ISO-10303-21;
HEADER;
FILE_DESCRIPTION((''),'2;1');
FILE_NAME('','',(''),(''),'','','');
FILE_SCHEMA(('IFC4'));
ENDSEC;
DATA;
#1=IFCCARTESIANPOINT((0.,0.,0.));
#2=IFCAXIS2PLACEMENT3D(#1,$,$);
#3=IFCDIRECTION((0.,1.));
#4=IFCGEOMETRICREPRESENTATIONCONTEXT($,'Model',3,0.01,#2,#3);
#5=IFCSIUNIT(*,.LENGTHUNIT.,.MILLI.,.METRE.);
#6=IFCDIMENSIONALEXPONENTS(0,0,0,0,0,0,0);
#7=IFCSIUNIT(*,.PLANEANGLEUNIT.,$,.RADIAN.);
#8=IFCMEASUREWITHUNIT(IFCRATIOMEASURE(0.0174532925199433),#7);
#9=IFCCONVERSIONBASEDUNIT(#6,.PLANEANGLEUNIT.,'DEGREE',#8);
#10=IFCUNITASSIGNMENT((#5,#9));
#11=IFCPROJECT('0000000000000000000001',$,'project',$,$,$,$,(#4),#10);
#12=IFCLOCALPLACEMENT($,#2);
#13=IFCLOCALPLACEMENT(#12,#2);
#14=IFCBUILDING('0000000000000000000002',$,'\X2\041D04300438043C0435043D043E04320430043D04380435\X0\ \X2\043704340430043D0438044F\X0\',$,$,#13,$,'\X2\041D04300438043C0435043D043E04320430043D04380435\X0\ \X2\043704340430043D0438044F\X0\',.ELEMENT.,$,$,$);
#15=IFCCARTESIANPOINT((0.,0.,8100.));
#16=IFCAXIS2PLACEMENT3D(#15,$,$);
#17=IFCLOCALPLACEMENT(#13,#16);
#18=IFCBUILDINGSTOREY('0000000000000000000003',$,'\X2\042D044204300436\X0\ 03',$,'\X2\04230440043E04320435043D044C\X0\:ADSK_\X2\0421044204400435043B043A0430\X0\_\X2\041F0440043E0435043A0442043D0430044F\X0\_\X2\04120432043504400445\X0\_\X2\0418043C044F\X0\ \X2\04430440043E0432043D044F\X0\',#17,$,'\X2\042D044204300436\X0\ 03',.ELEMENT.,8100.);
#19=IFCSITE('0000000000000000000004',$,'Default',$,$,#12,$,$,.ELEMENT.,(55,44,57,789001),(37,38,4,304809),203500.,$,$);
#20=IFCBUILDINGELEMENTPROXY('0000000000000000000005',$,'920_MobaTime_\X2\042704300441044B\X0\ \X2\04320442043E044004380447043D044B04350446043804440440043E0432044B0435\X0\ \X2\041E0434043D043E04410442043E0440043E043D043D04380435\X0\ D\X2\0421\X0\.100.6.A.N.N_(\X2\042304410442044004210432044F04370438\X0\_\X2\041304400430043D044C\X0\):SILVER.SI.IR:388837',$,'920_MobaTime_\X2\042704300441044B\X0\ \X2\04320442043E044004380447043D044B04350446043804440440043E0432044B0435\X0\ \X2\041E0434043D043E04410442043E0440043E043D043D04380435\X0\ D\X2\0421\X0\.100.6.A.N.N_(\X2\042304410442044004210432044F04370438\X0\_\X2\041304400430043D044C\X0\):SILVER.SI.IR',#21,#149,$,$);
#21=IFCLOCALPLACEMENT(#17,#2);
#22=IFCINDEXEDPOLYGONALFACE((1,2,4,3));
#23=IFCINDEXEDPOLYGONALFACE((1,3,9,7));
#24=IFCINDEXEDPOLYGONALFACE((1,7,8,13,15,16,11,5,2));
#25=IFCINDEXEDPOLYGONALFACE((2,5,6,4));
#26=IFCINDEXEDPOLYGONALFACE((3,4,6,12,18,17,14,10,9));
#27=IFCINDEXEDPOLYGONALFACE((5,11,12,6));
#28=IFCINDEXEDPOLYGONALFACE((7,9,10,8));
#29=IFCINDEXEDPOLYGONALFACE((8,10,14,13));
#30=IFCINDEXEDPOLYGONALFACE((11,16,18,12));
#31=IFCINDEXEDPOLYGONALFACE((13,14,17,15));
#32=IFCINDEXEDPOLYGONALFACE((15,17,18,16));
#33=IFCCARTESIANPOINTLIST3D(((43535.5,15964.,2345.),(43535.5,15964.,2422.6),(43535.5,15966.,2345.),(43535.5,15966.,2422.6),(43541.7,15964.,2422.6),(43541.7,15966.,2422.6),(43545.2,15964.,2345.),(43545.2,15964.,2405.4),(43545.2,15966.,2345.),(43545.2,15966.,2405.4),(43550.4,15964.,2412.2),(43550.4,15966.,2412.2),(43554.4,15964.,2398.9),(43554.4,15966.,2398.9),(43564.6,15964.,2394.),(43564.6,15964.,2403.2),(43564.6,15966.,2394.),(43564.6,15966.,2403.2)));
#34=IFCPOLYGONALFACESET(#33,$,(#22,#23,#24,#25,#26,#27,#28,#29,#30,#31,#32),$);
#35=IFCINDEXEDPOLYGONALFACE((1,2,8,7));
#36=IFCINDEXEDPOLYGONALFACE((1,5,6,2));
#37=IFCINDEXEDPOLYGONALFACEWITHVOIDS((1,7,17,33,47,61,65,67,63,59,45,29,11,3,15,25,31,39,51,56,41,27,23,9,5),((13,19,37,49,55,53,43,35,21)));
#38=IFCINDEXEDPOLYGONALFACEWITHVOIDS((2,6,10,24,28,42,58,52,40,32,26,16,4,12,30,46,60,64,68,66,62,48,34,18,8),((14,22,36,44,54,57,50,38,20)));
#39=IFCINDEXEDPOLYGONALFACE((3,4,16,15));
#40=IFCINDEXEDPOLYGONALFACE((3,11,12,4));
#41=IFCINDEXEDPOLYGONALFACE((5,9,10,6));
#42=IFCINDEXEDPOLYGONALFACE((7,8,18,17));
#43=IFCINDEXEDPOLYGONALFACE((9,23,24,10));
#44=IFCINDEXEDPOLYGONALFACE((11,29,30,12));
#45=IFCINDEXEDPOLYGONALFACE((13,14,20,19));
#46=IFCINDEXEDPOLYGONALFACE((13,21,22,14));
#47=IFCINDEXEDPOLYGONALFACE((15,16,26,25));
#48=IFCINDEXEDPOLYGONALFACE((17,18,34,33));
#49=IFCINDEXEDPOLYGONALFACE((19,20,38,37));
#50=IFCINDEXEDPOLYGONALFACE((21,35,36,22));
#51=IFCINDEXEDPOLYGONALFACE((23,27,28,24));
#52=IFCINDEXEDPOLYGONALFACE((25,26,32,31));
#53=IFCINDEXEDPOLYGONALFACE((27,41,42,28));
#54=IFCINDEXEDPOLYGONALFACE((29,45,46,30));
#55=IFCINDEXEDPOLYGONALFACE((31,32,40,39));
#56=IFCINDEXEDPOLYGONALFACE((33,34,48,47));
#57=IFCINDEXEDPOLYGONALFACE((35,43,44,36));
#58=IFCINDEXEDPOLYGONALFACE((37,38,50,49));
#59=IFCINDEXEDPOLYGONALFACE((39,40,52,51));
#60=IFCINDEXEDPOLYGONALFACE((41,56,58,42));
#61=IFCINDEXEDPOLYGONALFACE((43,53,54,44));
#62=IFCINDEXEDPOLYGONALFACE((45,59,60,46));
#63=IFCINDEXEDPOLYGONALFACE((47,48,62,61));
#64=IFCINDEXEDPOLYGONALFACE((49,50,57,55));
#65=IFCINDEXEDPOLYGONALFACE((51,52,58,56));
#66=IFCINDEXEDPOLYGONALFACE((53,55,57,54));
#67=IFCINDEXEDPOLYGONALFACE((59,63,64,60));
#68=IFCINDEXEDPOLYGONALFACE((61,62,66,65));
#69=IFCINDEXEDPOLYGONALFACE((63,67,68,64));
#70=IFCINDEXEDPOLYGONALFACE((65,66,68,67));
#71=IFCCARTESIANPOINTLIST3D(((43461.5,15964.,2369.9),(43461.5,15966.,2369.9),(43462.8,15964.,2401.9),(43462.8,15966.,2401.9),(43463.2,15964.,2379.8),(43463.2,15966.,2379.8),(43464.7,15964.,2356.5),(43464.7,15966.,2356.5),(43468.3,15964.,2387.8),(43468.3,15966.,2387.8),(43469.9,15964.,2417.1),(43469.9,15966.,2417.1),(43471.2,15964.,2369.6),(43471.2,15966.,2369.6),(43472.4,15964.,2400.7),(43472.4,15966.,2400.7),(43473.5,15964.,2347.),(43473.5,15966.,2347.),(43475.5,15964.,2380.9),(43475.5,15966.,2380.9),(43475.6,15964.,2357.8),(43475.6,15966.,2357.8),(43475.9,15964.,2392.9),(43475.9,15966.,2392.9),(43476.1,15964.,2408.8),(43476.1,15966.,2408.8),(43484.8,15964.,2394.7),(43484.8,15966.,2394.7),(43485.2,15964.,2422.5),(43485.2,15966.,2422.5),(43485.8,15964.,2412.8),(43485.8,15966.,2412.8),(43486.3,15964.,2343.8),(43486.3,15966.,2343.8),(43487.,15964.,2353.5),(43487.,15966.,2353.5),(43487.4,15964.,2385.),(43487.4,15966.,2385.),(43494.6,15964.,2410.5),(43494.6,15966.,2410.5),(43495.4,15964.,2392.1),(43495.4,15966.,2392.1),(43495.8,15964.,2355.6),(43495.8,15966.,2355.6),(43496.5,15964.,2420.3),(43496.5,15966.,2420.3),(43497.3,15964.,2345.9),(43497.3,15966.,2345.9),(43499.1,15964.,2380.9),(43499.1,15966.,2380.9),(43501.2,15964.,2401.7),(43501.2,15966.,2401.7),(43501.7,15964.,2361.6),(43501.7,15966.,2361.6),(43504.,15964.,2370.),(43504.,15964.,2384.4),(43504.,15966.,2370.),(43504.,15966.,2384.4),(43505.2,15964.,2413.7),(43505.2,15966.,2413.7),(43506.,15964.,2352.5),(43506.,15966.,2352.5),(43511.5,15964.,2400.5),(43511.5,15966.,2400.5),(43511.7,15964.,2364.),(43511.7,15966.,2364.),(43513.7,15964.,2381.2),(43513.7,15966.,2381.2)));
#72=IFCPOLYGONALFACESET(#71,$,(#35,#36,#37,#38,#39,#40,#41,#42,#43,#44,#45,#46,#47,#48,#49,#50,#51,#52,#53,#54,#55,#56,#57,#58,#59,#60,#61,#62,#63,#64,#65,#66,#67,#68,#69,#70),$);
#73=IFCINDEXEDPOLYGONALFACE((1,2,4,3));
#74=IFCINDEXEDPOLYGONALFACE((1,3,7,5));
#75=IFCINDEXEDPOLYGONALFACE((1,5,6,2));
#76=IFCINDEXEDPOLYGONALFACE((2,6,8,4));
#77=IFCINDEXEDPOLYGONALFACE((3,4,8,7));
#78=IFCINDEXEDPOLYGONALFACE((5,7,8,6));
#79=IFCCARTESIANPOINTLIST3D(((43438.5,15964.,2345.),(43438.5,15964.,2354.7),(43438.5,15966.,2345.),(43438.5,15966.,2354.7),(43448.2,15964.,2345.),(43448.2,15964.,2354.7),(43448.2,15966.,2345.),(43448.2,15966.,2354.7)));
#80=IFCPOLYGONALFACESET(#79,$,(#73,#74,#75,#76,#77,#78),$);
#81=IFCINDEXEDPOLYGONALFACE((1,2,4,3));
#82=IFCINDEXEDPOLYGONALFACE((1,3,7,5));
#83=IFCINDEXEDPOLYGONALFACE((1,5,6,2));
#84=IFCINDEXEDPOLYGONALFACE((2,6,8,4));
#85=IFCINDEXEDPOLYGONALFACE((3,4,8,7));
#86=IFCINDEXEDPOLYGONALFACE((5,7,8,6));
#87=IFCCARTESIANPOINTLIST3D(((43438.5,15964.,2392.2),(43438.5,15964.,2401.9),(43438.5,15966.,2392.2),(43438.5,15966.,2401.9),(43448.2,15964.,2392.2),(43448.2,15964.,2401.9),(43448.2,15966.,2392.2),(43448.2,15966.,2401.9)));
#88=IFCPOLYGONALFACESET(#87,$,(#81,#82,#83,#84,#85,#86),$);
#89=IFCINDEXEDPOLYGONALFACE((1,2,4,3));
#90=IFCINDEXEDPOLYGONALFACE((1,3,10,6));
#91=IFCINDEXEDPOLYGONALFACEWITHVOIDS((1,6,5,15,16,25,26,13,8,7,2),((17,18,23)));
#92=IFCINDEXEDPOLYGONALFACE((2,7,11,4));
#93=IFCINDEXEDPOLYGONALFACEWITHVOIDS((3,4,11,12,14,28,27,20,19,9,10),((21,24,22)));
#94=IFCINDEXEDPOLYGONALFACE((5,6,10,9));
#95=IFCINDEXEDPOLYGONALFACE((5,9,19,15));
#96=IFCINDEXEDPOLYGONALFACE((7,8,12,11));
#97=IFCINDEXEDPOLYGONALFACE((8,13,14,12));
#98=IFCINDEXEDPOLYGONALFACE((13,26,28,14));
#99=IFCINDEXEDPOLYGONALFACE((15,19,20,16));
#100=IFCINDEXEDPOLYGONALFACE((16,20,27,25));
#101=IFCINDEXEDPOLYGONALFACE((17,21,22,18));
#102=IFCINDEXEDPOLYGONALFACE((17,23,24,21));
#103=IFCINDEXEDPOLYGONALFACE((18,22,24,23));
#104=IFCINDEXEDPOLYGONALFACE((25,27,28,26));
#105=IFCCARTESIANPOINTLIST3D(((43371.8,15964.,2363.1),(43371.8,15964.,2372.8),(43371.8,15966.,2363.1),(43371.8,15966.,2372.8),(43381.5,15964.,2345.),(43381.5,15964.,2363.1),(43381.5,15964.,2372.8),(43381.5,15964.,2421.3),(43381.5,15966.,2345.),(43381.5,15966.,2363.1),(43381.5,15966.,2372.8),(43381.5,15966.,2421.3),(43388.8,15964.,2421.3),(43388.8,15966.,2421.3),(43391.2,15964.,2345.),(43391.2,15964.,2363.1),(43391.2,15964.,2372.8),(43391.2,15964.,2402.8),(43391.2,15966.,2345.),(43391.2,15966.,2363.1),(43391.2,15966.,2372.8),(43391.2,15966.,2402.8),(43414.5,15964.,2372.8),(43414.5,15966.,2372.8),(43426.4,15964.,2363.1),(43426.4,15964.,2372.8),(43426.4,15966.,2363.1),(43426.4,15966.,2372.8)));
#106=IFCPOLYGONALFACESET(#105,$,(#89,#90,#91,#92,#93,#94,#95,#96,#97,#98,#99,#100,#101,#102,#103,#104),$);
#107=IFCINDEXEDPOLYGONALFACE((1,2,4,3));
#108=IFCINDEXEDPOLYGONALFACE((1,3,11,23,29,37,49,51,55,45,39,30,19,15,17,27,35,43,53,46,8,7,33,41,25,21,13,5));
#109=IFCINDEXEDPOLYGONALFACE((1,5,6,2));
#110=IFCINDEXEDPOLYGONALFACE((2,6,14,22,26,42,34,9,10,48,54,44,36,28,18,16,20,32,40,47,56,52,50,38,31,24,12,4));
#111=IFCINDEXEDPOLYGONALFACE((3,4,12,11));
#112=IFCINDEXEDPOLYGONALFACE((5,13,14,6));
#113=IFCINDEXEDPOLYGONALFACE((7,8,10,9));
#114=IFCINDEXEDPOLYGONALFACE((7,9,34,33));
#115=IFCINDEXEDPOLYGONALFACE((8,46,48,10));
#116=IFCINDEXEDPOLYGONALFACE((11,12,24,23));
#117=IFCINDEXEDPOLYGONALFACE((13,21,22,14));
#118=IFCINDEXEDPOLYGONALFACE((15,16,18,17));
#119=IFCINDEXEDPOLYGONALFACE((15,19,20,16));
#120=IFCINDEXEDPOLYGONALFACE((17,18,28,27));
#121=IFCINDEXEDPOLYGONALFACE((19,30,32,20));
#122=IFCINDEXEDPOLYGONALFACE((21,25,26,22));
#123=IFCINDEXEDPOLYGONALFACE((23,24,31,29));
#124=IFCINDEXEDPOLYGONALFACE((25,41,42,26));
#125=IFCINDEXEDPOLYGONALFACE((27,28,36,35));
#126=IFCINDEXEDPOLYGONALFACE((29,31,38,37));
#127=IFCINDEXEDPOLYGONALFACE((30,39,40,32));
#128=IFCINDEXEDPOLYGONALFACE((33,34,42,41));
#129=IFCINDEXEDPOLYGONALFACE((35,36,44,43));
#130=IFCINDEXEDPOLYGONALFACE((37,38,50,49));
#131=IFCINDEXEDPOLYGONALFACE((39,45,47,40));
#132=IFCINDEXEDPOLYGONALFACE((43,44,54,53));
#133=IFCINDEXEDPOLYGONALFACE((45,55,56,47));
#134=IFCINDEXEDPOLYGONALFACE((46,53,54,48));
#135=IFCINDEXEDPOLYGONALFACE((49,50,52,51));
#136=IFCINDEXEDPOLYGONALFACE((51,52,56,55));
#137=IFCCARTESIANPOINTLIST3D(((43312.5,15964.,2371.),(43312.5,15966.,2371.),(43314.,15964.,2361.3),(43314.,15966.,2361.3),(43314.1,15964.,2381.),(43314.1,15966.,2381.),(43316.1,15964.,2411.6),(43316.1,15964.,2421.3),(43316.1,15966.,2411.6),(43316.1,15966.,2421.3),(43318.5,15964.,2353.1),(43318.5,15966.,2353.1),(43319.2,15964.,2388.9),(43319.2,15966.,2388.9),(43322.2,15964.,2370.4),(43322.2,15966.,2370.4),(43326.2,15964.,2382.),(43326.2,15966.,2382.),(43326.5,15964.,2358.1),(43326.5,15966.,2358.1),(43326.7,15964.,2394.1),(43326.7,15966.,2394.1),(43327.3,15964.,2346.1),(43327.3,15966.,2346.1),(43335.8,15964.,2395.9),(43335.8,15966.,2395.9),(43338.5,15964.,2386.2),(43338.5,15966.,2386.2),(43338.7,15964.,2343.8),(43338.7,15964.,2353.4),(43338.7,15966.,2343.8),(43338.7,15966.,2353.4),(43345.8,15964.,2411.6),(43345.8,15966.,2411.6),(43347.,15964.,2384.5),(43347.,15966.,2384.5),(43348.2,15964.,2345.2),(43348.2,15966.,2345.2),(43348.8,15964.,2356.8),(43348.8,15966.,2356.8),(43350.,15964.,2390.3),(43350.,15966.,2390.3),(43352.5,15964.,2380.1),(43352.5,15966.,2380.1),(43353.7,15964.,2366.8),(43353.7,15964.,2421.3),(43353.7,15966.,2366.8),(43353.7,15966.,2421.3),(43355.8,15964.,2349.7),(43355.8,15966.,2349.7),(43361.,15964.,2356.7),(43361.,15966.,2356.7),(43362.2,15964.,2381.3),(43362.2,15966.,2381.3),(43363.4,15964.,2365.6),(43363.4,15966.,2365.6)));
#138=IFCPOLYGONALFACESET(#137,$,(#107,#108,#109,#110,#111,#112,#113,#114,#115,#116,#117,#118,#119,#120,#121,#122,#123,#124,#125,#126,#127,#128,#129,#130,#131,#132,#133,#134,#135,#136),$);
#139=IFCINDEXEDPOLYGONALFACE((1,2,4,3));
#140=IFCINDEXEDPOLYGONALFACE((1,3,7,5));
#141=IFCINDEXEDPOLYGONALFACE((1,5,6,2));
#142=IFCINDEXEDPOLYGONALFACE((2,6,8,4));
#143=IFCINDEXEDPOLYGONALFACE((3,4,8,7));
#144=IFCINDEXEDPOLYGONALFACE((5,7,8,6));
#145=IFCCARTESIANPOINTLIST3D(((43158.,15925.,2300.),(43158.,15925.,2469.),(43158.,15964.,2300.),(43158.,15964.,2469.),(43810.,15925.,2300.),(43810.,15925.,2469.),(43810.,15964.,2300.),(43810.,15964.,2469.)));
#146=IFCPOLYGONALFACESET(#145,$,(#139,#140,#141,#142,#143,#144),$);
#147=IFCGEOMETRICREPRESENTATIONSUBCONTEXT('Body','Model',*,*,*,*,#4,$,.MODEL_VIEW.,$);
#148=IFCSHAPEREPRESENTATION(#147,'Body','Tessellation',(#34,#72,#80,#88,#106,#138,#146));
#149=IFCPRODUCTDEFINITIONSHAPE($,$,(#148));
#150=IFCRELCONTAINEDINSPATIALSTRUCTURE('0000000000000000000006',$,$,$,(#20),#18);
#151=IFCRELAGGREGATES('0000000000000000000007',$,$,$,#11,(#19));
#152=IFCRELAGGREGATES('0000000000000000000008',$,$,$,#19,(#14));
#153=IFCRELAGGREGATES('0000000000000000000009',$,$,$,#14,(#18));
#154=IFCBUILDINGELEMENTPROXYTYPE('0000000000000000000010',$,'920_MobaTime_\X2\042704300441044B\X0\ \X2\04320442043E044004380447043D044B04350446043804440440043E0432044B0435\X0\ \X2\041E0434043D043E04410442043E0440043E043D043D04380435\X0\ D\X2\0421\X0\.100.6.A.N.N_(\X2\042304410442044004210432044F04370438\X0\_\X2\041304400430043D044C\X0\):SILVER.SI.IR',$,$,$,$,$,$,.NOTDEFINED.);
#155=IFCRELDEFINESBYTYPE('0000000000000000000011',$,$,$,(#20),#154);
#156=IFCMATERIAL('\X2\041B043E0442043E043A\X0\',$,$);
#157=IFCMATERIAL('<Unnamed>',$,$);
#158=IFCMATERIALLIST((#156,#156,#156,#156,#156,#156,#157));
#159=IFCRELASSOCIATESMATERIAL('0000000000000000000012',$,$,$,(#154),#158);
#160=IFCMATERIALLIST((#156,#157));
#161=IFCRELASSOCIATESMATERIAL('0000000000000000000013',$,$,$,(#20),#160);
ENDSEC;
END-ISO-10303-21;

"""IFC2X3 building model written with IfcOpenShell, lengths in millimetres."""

from ifc_helpers import new_model, entity, si_unit, converted_unit, direction, frame, origin, origin_2d_with_axis, place, context, subcontext, project, spatial, polyline, rectangle, outline, extrude, source, transform, mapped, material, material_list, type_object, type_shapes, element, save


model = new_model("IFC2X3")

# Units and contexts
model_context = context("Model", 3, precision=0.01, world=origin(), true_north=direction((0.0, 1.0)))
body_context = subcontext(model_context, "Body", "Model", "MODEL_VIEW")
ifc_project = project(units=[si_unit("LENGTHUNIT", "METRE", prefix="MILLI"), converted_unit("PLANEANGLEUNIT", "DEGREE", entity("IfcRatioMeasure", 0.0174532925199433), si_unit("PLANEANGLEUNIT", "RADIAN"), dimensions=[0, 0, 0, 0, 0, 0, 0])], contexts=[model_context])

# Site, building, storey
site_placement = place(None, origin())
site = spatial("IfcSite", under=ifc_project, at=site_placement, Name="Default", CompositionType="ELEMENT", RefLatitude=(55, 44, 57, 789001), RefLongitude=(37, 38, 4, 304809), RefElevation=203500.0)
building_placement = place(site_placement, origin())
building = spatial("IfcBuilding", under=site, at=building_placement, Name="Наименование здания", LongName="Наименование здания", CompositionType="ELEMENT")
storey_placement = place(building_placement, frame((0.0, 0.0, 8100.0)))
storey = spatial("IfcBuildingStorey", under=building, at=storey_placement, Name="Этаж 03", ObjectType="Уровень:ADSK_Стрелка_Проектная_Вверх_Имя уровня", LongName="Этаж 03", CompositionType="ELEMENT", Elevation=8100.0)

# Building element proxy
ifc_material_1 = material(Name="Лоток")
ifc_material_2 = material(Name="<Unnamed>")
ifc_material_list_1 = material_list([ifc_material_1, ifc_material_1, ifc_material_1, ifc_material_1, ifc_material_1, ifc_material_1, ifc_material_2])
building_element_proxy_type = type_object("IfcBuildingElementProxyType", Name="920_MobaTime_Часы вторичныецифровые Односторонние DС.100.6.A.N.N_(УстрСвязи_Грань):SILVER.SI.IR", PredefinedType="NOTDEFINED", material=ifc_material_list_1)
shared_shape = source(origin(), body_context, "Body", "SweptSolid", [
    extrude(outline(polyline([(-49.3, -13.1), (28.2, -13.1), (28.2, -6.8), (17.9, 1.8), (8.8, 16.0), (-0.3, 16.0), (4.6, 5.8), (11.1, -3.4), (-49.3, -3.4), (-49.3, -13.1)])), frame((-64.6, 9.8, 39.0), z_axis=(0.0, 0.0, 1.0), x_axis=(0.0, 1.0, 0.0)), (0.0, 0.0, 1.0), 2.0),
    extrude(outline(polyline([(2.2, -27.6), (19.0, -27.6), (30.5, -16.1), (33.3, -4.9), (31.0, 5.8), (21.8, 17.2), (5.2, 27.3), (-11.1, 33.0), (-24.0, 32.7), (-33.6, 27.6), (-40.3, 18.6), (-42.8, 5.7), (-38.0, -6.3), (-27.2, -14.9), (-17.5, -17.7), (-8.2, -16.4), (-0.3, -11.9), (5.1, -4.5), (7.3, 6.2), (4.0, 17.2), (18.4, 7.3), (23.6, -2.4), (22.0, -11.4), (14.2, -18.4), (5.3, -18.3), (2.2, -27.6)]), holes=[polyline([(-9.0, 23.3), (-1.3, 14.3), (-2.5, 2.0), (-11.4, -7.0), (-23.4, -6.0), (-32.2, 2.9), (-31.2, 15.1), (-25.6, 22.1), (-17.5, 24.9), (-9.0, 23.3)])]), frame((-2.7, 3.6, 39.0), z_axis=(0.0, 0.0, 1.0), x_axis=(-0.427649, 0.903945, 0.0)), (0.0, 0.0, 1.0), 2.0),
    extrude(rectangle(XDim=9.7, YDim=9.7, at=origin_2d_with_axis()), frame((40.6, -34.7, 39.0)), (0.0, 0.0, 1.0), 2.0),
    extrude(rectangle(XDim=9.7, YDim=9.7, at=origin_2d_with_axis()), frame((40.6, 12.6, 39.0)), (0.0, 0.0, 1.0), 2.0),
    extrude(outline(polyline([(-0.9, -28.1), (8.8, -28.1), (8.8, -9.9), (18.5, -9.9), (18.5, -0.2), (8.8, -0.2), (8.8, 48.3), (1.5, 48.3), (-36.0, -0.2), (-36.0, -9.9), (-0.9, -9.9), (-0.9, -28.1)]), holes=[polyline([(-0.9, -0.2), (-24.1, -0.2), (-0.9, 29.7), (-0.9, -0.2)])]), frame((93.6, -11.4, 39.0)), (0.0, 0.0, 1.0), 2.0),
    extrude(outline(polyline([(3.3, -28.3), (12.5, -28.3), (20.5, -25.0), (26.8, -18.9), (30.7, -10.0), (31.4, 1.6), (26.9, 11.8), (20.1, 18.4), (11.1, 22.3), (1.0, 23.3), (-7.9, 20.4), (-14.9, 14.5), (-18.9, 6.2), (-17.1, -9.0), (-36.7, 0.5), (-29.1, 29.2), (-38.5, 31.7), (-48.1, -4.6), (-11.6, -23.1), (-8.0, -14.0), (-10.8, -7.6), (-10.2, 1.1), (-3.0, 11.8), (9.2, 12.8), (20.0, 5.5), (21.4, -7.5), (15.5, -16.4), (4.6, -18.6), (3.3, -28.3)])), frame((147.1, -8.5, 39.0), z_axis=(0.0, 0.0, 1.0), x_axis=(0.256974, -0.966418, 0.0)), (0.0, 0.0, 1.0), 2.0),
    extrude(rectangle(XDim=652.0, YDim=169.0, at=origin_2d_with_axis()), frame((0.0, 0.0, 0.0), z_axis=(0.0, 0.0, 1.0), x_axis=(-1.0, 0.0, 0.0)), (0.0, 0.0, 1.0), 39.0),
])
type_shapes(building_element_proxy_type, [shared_shape])
ifc_material_list_2 = material_list([ifc_material_1, ifc_material_2])
for number, where, z_axis, x_axis, name in (
    (1, (43484.0, 15925.0, 2384.5), (0.0, 1.0, 0.0), (-1.0, 0.0, 0.0), "920_MobaTime_Часы вторичныецифровые Односторонние DС.100.6.A.N.N_(УстрСвязи_Грань):SILVER.SI.IR:388837"),
):
    element("IfcBuildingElementProxy", number, at=place(storey_placement, frame(where, z_axis=z_axis, x_axis=x_axis)), inside=storey, type_object=building_element_proxy_type, material=ifc_material_list_2, Name=name, ObjectType="920_MobaTime_Часы вторичныецифровые Односторонние DС.100.6.A.N.N_(УстрСвязи_Грань):SILVER.SI.IR", context=body_context, shape_type="MappedRepresentation", body=[
        mapped(shared_shape, transform((0.0, 0.0, 0.0), scale=1.0)),
    ])

save(model, "model.ifc")
